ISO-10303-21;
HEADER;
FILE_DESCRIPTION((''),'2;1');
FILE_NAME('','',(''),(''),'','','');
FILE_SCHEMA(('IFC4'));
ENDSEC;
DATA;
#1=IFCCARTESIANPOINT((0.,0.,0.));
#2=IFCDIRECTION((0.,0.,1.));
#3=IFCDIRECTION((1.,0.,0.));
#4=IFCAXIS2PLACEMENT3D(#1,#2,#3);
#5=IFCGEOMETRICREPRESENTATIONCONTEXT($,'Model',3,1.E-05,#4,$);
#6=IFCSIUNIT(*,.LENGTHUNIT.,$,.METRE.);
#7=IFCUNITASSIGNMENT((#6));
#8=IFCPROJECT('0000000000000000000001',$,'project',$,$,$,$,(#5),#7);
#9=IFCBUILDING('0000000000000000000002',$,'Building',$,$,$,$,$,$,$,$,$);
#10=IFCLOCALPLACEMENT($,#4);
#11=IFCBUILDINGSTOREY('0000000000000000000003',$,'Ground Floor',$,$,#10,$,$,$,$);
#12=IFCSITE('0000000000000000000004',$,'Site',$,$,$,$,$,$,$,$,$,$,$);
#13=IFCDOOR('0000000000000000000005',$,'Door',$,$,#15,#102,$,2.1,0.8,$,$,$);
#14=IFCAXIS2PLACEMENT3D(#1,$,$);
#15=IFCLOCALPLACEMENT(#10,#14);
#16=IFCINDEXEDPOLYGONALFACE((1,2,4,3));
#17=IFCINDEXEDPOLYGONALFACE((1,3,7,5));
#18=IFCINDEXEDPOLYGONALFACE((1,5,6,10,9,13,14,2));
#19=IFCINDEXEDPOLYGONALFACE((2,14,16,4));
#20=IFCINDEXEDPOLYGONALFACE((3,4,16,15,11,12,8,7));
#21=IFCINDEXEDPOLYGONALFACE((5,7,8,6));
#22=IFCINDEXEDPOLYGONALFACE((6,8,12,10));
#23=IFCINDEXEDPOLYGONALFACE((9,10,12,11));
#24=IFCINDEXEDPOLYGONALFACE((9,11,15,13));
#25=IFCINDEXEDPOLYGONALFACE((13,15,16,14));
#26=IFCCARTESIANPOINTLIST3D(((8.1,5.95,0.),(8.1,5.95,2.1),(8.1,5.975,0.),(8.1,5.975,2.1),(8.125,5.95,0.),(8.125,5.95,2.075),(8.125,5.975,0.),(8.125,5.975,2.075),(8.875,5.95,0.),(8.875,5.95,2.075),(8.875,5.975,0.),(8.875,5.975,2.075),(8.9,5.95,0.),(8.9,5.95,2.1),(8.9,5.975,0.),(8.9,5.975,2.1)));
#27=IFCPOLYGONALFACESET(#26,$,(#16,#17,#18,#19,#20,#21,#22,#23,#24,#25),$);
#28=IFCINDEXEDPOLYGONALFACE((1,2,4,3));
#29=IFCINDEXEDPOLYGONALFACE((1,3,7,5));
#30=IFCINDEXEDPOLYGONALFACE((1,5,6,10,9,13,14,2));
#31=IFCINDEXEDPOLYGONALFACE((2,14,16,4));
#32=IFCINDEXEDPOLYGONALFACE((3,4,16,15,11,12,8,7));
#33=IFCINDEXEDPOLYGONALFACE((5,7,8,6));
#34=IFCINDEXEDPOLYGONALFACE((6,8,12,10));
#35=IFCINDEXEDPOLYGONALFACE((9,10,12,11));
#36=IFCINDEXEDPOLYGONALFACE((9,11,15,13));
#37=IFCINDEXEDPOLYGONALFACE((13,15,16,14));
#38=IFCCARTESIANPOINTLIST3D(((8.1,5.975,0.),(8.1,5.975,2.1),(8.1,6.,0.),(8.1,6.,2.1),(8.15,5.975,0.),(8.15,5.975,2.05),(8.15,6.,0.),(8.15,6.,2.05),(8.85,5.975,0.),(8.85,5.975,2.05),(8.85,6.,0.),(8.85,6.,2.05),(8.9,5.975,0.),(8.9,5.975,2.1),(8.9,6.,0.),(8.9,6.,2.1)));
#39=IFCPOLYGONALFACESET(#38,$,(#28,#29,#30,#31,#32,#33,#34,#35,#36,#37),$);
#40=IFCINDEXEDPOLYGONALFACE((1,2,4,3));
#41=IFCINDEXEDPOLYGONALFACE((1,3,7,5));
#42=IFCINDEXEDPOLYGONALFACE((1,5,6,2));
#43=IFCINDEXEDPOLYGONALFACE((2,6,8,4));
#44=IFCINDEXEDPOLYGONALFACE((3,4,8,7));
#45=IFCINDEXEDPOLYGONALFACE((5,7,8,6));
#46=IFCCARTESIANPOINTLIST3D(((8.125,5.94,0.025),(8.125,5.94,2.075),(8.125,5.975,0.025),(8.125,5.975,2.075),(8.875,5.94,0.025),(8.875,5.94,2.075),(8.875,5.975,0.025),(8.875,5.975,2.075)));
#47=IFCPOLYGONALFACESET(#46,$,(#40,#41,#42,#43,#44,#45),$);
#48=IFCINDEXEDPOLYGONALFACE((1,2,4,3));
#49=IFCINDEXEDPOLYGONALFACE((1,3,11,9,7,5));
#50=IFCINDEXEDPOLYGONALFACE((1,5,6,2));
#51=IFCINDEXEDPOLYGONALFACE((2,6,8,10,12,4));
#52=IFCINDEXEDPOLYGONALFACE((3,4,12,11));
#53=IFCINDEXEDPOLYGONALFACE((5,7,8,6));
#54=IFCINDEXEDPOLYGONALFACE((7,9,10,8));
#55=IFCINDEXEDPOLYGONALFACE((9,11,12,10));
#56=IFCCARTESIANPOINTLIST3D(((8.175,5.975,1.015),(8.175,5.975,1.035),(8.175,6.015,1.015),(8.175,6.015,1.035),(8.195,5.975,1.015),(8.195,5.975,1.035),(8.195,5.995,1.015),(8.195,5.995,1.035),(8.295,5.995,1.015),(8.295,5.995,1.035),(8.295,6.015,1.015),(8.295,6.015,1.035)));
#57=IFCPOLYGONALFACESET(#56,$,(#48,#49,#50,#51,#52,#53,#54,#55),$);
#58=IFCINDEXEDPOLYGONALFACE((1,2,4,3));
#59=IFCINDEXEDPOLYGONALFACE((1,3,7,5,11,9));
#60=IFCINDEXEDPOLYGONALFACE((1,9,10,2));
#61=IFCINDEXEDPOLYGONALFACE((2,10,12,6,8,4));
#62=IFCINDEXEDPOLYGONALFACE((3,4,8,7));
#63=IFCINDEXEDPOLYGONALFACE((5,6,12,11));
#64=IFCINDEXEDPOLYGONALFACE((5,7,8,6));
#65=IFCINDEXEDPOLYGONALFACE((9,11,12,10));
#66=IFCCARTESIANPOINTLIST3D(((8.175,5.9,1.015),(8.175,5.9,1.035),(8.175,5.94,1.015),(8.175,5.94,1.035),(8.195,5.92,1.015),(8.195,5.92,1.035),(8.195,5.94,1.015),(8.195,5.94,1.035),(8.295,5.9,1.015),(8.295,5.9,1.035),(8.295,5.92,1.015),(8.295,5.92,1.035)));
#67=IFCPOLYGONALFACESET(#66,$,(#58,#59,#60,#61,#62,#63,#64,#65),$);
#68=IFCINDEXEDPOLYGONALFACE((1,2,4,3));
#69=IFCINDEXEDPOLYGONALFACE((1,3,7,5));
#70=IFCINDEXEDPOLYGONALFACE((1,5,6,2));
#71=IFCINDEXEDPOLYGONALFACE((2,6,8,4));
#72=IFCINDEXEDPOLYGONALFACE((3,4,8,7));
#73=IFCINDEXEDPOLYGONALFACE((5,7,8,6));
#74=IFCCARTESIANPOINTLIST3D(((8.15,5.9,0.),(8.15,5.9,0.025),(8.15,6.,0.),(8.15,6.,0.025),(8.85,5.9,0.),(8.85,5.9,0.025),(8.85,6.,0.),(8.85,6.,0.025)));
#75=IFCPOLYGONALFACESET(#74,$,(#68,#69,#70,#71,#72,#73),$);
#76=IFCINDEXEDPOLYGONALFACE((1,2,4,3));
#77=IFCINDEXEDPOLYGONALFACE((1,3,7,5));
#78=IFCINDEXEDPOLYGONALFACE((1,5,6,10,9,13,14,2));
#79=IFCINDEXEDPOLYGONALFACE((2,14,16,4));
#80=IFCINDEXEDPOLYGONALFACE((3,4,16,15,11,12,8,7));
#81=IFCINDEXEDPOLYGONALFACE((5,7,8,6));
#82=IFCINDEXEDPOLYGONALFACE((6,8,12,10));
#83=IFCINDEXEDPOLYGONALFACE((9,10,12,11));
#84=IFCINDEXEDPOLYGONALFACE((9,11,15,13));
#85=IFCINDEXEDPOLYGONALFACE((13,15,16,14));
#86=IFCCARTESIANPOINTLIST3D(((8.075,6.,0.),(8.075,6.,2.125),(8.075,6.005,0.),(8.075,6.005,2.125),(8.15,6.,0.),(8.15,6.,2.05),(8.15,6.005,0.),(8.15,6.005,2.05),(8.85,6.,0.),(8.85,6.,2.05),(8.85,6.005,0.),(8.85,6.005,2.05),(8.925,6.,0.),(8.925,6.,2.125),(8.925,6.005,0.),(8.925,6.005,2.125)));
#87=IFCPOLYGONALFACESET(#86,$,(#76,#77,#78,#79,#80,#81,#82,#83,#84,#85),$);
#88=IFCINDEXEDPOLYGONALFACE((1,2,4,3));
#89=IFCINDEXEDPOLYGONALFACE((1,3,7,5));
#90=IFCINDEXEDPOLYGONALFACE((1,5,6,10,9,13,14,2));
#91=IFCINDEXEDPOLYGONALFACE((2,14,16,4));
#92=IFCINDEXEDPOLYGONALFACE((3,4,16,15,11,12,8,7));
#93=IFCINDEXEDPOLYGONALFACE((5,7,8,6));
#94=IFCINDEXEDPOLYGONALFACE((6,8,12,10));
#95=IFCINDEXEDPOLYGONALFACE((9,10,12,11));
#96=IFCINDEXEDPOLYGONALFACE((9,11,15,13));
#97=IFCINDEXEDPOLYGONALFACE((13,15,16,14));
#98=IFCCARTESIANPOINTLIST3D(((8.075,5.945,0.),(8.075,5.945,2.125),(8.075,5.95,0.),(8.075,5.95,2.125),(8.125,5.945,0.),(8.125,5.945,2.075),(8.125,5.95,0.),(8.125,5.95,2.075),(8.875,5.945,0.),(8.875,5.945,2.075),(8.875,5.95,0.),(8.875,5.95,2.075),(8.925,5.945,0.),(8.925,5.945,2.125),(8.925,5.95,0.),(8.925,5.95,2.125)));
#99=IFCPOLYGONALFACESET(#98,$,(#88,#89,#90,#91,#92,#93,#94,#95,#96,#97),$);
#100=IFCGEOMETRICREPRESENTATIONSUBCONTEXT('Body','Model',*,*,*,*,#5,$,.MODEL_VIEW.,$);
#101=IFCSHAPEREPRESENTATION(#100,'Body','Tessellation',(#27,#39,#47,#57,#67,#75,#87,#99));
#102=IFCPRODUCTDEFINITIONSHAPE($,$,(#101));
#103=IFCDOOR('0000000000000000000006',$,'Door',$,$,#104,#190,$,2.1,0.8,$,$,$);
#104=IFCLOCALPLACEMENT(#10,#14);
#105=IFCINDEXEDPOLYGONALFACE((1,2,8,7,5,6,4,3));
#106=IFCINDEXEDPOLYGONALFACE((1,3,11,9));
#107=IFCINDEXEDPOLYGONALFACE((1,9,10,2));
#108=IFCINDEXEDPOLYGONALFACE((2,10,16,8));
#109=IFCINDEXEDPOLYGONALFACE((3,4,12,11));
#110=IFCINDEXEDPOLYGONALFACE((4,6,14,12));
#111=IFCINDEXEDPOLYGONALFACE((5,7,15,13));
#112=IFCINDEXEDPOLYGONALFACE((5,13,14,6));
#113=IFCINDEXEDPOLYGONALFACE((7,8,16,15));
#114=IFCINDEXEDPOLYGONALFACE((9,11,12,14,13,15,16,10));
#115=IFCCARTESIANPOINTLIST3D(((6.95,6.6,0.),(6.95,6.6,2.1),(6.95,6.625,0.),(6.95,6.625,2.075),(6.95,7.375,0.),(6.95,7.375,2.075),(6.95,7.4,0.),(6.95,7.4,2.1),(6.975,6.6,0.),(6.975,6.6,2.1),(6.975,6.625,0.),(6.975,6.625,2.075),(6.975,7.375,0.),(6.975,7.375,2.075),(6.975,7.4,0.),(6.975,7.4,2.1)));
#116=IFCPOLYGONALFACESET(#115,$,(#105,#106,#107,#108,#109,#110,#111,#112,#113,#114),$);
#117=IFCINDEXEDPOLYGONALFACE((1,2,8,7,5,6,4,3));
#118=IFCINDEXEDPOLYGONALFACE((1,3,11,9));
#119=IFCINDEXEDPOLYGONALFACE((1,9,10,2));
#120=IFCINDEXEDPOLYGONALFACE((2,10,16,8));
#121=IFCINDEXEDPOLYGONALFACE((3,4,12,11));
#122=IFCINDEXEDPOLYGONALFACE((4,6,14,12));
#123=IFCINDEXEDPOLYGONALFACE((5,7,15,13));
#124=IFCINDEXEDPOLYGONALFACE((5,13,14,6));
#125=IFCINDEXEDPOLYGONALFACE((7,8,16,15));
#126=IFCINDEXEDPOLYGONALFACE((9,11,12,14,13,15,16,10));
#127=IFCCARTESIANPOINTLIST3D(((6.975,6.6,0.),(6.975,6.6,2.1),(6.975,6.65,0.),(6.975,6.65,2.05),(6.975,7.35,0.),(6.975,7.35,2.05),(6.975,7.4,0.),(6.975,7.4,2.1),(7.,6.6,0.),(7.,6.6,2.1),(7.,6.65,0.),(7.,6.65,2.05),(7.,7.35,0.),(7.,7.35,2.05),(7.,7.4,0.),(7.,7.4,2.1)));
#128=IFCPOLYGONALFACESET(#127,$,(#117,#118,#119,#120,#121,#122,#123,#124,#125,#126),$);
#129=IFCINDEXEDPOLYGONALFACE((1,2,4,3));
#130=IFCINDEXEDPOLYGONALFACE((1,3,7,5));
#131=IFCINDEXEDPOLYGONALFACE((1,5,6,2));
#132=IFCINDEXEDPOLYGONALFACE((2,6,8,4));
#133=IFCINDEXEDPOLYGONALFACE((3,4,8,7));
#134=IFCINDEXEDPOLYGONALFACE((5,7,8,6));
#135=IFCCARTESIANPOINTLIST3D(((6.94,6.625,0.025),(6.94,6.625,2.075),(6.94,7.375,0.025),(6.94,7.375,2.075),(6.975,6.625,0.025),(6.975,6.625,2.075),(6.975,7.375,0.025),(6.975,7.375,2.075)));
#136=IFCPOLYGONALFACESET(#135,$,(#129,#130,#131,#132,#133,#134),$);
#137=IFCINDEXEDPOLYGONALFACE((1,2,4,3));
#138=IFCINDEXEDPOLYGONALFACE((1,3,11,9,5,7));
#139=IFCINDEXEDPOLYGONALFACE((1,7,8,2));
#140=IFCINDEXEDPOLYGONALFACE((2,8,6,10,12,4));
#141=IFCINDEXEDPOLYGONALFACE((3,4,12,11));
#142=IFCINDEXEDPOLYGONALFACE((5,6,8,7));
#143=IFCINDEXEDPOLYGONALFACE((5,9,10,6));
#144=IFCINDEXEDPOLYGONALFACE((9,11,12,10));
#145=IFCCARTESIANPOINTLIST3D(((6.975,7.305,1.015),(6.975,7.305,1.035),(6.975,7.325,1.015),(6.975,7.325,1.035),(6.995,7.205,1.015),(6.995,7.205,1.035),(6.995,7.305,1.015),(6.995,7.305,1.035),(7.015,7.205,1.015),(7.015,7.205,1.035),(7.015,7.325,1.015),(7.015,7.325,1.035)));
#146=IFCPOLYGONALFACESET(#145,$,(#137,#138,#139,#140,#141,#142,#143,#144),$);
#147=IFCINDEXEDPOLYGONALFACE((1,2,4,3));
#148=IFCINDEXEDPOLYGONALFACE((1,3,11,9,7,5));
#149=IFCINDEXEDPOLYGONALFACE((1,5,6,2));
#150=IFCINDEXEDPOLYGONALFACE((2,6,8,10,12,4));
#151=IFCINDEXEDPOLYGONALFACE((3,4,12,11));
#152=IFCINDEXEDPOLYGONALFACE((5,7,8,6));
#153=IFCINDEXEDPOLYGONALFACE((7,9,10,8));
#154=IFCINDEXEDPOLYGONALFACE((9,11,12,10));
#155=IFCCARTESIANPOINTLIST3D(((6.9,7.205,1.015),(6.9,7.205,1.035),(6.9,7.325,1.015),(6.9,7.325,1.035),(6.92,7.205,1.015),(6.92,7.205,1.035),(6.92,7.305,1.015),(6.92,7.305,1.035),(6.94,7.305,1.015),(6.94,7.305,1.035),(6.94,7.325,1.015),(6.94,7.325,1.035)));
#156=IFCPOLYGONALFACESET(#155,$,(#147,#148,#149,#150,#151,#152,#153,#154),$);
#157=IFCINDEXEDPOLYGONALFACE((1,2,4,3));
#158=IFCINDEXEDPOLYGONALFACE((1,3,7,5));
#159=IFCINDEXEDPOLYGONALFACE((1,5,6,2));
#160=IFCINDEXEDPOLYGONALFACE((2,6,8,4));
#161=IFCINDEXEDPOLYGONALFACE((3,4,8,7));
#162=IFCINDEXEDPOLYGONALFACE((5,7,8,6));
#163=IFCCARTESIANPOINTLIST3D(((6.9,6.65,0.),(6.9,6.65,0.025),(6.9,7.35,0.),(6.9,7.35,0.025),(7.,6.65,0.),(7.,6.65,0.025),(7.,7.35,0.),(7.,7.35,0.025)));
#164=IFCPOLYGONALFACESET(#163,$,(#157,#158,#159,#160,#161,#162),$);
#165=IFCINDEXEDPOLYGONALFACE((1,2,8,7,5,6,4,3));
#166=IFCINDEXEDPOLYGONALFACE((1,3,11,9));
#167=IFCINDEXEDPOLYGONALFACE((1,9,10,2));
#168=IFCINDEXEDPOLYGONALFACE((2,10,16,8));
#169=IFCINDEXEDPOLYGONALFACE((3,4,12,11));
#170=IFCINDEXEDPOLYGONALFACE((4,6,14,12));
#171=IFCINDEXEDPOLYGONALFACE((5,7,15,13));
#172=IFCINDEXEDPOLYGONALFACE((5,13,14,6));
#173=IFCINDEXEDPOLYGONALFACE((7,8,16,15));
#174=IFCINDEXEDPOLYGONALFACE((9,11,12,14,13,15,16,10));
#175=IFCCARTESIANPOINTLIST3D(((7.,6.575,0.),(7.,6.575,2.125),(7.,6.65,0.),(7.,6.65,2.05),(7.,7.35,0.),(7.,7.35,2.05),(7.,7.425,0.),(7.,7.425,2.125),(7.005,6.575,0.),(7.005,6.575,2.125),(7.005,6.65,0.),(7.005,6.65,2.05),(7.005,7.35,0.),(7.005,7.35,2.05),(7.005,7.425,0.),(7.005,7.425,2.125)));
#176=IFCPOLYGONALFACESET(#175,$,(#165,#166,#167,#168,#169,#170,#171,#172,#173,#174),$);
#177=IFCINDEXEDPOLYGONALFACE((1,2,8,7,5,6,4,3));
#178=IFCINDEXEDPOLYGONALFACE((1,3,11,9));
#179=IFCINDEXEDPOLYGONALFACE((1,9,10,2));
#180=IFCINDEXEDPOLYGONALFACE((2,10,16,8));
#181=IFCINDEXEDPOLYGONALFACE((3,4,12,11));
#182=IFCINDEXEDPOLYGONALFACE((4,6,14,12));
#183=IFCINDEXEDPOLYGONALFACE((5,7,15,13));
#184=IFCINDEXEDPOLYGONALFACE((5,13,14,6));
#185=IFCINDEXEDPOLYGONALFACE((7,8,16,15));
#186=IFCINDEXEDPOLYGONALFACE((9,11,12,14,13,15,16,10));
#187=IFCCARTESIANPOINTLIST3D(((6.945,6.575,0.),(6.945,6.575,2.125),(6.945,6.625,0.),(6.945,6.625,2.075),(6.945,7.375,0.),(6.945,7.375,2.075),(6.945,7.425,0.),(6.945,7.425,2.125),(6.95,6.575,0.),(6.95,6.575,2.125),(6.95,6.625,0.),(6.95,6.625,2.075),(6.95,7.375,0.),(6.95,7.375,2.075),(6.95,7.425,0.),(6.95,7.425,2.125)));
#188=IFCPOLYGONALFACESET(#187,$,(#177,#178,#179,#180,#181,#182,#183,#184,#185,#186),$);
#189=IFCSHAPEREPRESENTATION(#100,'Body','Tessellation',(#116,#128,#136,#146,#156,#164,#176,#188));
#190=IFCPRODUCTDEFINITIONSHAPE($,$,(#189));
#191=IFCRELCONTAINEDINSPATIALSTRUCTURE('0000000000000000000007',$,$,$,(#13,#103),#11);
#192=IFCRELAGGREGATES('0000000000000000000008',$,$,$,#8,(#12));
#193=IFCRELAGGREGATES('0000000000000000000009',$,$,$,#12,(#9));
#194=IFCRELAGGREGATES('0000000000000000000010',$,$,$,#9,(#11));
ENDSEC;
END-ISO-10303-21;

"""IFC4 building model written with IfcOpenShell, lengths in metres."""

from ifc_helpers import new_model, si_unit, frame, origin_with_axes, place, context, subcontext, project, spatial, line, indexed_curve, outline, extrude, element, save


model = new_model("IFC4")

# Units and contexts
model_context = context("Model", 3, precision=1e-05, world=origin_with_axes())
body_context = subcontext(model_context, "Body", "Model", "MODEL_VIEW")
ifc_project = project(units=[si_unit("LENGTHUNIT", "METRE")], contexts=[model_context])

# Site, building, storey
site = spatial("IfcSite", under=ifc_project, Name="Site")
building = spatial("IfcBuilding", under=site, Name="Building")
storey_placement = place(None, origin_with_axes())
storey = spatial("IfcBuildingStorey", under=building, at=storey_placement, Name="Ground Floor")

# Doors
door_1_placement = place(storey_placement, frame((8.9, 6.0, 0.0), z_axis=(0.0, 0.0, 1.0), x_axis=(-1.0, 0.0, 0.0)))
element("IfcDoor", 1, at=door_1_placement, inside=storey, Name="Door", OverallHeight=2.1, OverallWidth=0.8, context=body_context, shape_type="SweptSolid", body=[
    extrude(outline(indexed_curve([(0.0, 0.0), (0.0, 2.1), (0.8, 2.1), (0.8, 0.0), (0.775, 0.0), (0.775, 2.075), (0.025, 2.075), (0.025, 0.0)], segments=[line(1, 2, 3, 4, 5, 6, 7, 8, 1)])), frame((0.0, 0.025, 0.0), z_axis=(0.0, -1.0, 0.0), x_axis=(1.0, 0.0, 0.0)), (0.0, 0.0, -1.0), 0.025),
    extrude(outline(indexed_curve([(0.0, 0.0), (0.0, 2.1), (0.8, 2.1), (0.8, 0.0), (0.75, 0.0), (0.75, 2.05), (0.05, 2.05), (0.05, 0.0)], segments=[line(1, 2, 3, 4, 5, 6, 7, 8, 1)])), frame((0.0, 0.0, 0.0), z_axis=(0.0, -1.0, 0.0), x_axis=(1.0, 0.0, 0.0)), (0.0, 0.0, -1.0), 0.025),
    extrude(outline(indexed_curve([(0.0, 0.0), (0.75, 0.0), (0.75, 0.035), (0.0, 0.035)], segments=[line(1, 2, 3, 4, 1)])), frame((0.025, 0.025, 0.025), z_axis=(0.0, 0.0, 1.0), x_axis=(1.0, 0.0, 0.0)), (0.0, 0.0, 1.0), 2.05),
    extrude(outline(indexed_curve([(0.0, 0.0), (0.0, -0.04), (-0.12, -0.04), (-0.12, -0.02), (-0.02, -0.02), (-0.02, 0.0)], segments=[line(1, 2, 3, 4, 5, 6, 1)])), frame((0.725, 0.025, 1.015), z_axis=(0.0, 0.0, 1.0), x_axis=(1.0, 0.0, 0.0)), (0.0, 0.0, 1.0), 0.02),
    extrude(outline(indexed_curve([(0.0, 0.0), (0.0, 0.04), (-0.12, 0.04), (-0.12, 0.02), (-0.02, 0.02), (-0.02, 0.0)], segments=[line(1, 2, 3, 4, 5, 6, 1)])), frame((0.725, 0.06, 1.015), z_axis=(0.0, 0.0, 1.0), x_axis=(1.0, 0.0, 0.0)), (0.0, 0.0, 1.0), 0.02),
    extrude(outline(indexed_curve([(0.0, 0.0), (0.7, 0.0), (0.7, 0.1), (0.0, 0.1)], segments=[line(1, 2, 3, 4, 1)])), frame((0.05, 0.0, 0.0), z_axis=(0.0, 0.0, 1.0), x_axis=(1.0, 0.0, 0.0)), (0.0, 0.0, 1.0), 0.025),
    extrude(outline(indexed_curve([(0.0, 0.0), (0.0, 2.125), (0.85, 2.125), (0.85, 0.0), (0.775, 0.0), (0.775, 2.05), (0.075, 2.05), (0.075, 0.0)], segments=[line(1, 2, 3, 4, 5, 6, 7, 8, 1)])), frame((-0.025, -0.005, 0.0), z_axis=(0.0, -1.0, 0.0), x_axis=(1.0, 0.0, 0.0)), (0.0, 0.0, -1.0), 0.005),
    extrude(outline(indexed_curve([(0.0, 0.0), (0.0, 2.125), (0.85, 2.125), (0.85, 0.0), (0.8, 0.0), (0.8, 2.075), (0.05, 2.075), (0.05, 0.0)], segments=[line(1, 2, 3, 4, 5, 6, 7, 8, 1)])), frame((-0.025, 0.05, 0.0), z_axis=(0.0, -1.0, 0.0), x_axis=(1.0, 0.0, 0.0)), (0.0, 0.0, -1.0), 0.005),
])
door_2_placement = place(storey_placement, frame((7.0, 6.6, 0.0), z_axis=(0.0, 0.0, 1.0), x_axis=(0.0, 1.0, 0.0)))
element("IfcDoor", 2, at=door_2_placement, inside=storey, Name="Door", OverallHeight=2.1, OverallWidth=0.8, context=body_context, shape_type="SweptSolid", body=[
    extrude(outline(indexed_curve([(0.0, 0.0), (0.0, 2.1), (0.8, 2.1), (0.8, 0.0), (0.775, 0.0), (0.775, 2.075), (0.025, 2.075), (0.025, 0.0)], segments=[line(1, 2, 3, 4, 5, 6, 7, 8, 1)])), frame((0.0, 0.025, 0.0), z_axis=(0.0, -1.0, 0.0), x_axis=(1.0, 0.0, 0.0)), (0.0, 0.0, -1.0), 0.025),
    extrude(outline(indexed_curve([(0.0, 0.0), (0.0, 2.1), (0.8, 2.1), (0.8, 0.0), (0.75, 0.0), (0.75, 2.05), (0.05, 2.05), (0.05, 0.0)], segments=[line(1, 2, 3, 4, 5, 6, 7, 8, 1)])), frame((0.0, 0.0, 0.0), z_axis=(0.0, -1.0, 0.0), x_axis=(1.0, 0.0, 0.0)), (0.0, 0.0, -1.0), 0.025),
    extrude(outline(indexed_curve([(0.0, 0.0), (0.75, 0.0), (0.75, 0.035), (0.0, 0.035)], segments=[line(1, 2, 3, 4, 1)])), frame((0.025, 0.025, 0.025), z_axis=(0.0, 0.0, 1.0), x_axis=(1.0, 0.0, 0.0)), (0.0, 0.0, 1.0), 2.05),
    extrude(outline(indexed_curve([(0.0, 0.0), (0.0, -0.04), (-0.12, -0.04), (-0.12, -0.02), (-0.02, -0.02), (-0.02, 0.0)], segments=[line(1, 2, 3, 4, 5, 6, 1)])), frame((0.725, 0.025, 1.015), z_axis=(0.0, 0.0, 1.0), x_axis=(1.0, 0.0, 0.0)), (0.0, 0.0, 1.0), 0.02),
    extrude(outline(indexed_curve([(0.0, 0.0), (0.0, 0.04), (-0.12, 0.04), (-0.12, 0.02), (-0.02, 0.02), (-0.02, 0.0)], segments=[line(1, 2, 3, 4, 5, 6, 1)])), frame((0.725, 0.06, 1.015), z_axis=(0.0, 0.0, 1.0), x_axis=(1.0, 0.0, 0.0)), (0.0, 0.0, 1.0), 0.02),
    extrude(outline(indexed_curve([(0.0, 0.0), (0.7, 0.0), (0.7, 0.1), (0.0, 0.1)], segments=[line(1, 2, 3, 4, 1)])), frame((0.05, 0.0, 0.0), z_axis=(0.0, 0.0, 1.0), x_axis=(1.0, 0.0, 0.0)), (0.0, 0.0, 1.0), 0.025),
    extrude(outline(indexed_curve([(0.0, 0.0), (0.0, 2.125), (0.85, 2.125), (0.85, 0.0), (0.775, 0.0), (0.775, 2.05), (0.075, 2.05), (0.075, 0.0)], segments=[line(1, 2, 3, 4, 5, 6, 7, 8, 1)])), frame((-0.025, -0.005, 0.0), z_axis=(0.0, -1.0, 0.0), x_axis=(1.0, 0.0, 0.0)), (0.0, 0.0, -1.0), 0.005),
    extrude(outline(indexed_curve([(0.0, 0.0), (0.0, 2.125), (0.85, 2.125), (0.85, 0.0), (0.8, 0.0), (0.8, 2.075), (0.05, 2.075), (0.05, 0.0)], segments=[line(1, 2, 3, 4, 5, 6, 7, 8, 1)])), frame((-0.025, 0.05, 0.0), z_axis=(0.0, -1.0, 0.0), x_axis=(1.0, 0.0, 0.0)), (0.0, 0.0, -1.0), 0.005),
])

save(model, "model.ifc")
